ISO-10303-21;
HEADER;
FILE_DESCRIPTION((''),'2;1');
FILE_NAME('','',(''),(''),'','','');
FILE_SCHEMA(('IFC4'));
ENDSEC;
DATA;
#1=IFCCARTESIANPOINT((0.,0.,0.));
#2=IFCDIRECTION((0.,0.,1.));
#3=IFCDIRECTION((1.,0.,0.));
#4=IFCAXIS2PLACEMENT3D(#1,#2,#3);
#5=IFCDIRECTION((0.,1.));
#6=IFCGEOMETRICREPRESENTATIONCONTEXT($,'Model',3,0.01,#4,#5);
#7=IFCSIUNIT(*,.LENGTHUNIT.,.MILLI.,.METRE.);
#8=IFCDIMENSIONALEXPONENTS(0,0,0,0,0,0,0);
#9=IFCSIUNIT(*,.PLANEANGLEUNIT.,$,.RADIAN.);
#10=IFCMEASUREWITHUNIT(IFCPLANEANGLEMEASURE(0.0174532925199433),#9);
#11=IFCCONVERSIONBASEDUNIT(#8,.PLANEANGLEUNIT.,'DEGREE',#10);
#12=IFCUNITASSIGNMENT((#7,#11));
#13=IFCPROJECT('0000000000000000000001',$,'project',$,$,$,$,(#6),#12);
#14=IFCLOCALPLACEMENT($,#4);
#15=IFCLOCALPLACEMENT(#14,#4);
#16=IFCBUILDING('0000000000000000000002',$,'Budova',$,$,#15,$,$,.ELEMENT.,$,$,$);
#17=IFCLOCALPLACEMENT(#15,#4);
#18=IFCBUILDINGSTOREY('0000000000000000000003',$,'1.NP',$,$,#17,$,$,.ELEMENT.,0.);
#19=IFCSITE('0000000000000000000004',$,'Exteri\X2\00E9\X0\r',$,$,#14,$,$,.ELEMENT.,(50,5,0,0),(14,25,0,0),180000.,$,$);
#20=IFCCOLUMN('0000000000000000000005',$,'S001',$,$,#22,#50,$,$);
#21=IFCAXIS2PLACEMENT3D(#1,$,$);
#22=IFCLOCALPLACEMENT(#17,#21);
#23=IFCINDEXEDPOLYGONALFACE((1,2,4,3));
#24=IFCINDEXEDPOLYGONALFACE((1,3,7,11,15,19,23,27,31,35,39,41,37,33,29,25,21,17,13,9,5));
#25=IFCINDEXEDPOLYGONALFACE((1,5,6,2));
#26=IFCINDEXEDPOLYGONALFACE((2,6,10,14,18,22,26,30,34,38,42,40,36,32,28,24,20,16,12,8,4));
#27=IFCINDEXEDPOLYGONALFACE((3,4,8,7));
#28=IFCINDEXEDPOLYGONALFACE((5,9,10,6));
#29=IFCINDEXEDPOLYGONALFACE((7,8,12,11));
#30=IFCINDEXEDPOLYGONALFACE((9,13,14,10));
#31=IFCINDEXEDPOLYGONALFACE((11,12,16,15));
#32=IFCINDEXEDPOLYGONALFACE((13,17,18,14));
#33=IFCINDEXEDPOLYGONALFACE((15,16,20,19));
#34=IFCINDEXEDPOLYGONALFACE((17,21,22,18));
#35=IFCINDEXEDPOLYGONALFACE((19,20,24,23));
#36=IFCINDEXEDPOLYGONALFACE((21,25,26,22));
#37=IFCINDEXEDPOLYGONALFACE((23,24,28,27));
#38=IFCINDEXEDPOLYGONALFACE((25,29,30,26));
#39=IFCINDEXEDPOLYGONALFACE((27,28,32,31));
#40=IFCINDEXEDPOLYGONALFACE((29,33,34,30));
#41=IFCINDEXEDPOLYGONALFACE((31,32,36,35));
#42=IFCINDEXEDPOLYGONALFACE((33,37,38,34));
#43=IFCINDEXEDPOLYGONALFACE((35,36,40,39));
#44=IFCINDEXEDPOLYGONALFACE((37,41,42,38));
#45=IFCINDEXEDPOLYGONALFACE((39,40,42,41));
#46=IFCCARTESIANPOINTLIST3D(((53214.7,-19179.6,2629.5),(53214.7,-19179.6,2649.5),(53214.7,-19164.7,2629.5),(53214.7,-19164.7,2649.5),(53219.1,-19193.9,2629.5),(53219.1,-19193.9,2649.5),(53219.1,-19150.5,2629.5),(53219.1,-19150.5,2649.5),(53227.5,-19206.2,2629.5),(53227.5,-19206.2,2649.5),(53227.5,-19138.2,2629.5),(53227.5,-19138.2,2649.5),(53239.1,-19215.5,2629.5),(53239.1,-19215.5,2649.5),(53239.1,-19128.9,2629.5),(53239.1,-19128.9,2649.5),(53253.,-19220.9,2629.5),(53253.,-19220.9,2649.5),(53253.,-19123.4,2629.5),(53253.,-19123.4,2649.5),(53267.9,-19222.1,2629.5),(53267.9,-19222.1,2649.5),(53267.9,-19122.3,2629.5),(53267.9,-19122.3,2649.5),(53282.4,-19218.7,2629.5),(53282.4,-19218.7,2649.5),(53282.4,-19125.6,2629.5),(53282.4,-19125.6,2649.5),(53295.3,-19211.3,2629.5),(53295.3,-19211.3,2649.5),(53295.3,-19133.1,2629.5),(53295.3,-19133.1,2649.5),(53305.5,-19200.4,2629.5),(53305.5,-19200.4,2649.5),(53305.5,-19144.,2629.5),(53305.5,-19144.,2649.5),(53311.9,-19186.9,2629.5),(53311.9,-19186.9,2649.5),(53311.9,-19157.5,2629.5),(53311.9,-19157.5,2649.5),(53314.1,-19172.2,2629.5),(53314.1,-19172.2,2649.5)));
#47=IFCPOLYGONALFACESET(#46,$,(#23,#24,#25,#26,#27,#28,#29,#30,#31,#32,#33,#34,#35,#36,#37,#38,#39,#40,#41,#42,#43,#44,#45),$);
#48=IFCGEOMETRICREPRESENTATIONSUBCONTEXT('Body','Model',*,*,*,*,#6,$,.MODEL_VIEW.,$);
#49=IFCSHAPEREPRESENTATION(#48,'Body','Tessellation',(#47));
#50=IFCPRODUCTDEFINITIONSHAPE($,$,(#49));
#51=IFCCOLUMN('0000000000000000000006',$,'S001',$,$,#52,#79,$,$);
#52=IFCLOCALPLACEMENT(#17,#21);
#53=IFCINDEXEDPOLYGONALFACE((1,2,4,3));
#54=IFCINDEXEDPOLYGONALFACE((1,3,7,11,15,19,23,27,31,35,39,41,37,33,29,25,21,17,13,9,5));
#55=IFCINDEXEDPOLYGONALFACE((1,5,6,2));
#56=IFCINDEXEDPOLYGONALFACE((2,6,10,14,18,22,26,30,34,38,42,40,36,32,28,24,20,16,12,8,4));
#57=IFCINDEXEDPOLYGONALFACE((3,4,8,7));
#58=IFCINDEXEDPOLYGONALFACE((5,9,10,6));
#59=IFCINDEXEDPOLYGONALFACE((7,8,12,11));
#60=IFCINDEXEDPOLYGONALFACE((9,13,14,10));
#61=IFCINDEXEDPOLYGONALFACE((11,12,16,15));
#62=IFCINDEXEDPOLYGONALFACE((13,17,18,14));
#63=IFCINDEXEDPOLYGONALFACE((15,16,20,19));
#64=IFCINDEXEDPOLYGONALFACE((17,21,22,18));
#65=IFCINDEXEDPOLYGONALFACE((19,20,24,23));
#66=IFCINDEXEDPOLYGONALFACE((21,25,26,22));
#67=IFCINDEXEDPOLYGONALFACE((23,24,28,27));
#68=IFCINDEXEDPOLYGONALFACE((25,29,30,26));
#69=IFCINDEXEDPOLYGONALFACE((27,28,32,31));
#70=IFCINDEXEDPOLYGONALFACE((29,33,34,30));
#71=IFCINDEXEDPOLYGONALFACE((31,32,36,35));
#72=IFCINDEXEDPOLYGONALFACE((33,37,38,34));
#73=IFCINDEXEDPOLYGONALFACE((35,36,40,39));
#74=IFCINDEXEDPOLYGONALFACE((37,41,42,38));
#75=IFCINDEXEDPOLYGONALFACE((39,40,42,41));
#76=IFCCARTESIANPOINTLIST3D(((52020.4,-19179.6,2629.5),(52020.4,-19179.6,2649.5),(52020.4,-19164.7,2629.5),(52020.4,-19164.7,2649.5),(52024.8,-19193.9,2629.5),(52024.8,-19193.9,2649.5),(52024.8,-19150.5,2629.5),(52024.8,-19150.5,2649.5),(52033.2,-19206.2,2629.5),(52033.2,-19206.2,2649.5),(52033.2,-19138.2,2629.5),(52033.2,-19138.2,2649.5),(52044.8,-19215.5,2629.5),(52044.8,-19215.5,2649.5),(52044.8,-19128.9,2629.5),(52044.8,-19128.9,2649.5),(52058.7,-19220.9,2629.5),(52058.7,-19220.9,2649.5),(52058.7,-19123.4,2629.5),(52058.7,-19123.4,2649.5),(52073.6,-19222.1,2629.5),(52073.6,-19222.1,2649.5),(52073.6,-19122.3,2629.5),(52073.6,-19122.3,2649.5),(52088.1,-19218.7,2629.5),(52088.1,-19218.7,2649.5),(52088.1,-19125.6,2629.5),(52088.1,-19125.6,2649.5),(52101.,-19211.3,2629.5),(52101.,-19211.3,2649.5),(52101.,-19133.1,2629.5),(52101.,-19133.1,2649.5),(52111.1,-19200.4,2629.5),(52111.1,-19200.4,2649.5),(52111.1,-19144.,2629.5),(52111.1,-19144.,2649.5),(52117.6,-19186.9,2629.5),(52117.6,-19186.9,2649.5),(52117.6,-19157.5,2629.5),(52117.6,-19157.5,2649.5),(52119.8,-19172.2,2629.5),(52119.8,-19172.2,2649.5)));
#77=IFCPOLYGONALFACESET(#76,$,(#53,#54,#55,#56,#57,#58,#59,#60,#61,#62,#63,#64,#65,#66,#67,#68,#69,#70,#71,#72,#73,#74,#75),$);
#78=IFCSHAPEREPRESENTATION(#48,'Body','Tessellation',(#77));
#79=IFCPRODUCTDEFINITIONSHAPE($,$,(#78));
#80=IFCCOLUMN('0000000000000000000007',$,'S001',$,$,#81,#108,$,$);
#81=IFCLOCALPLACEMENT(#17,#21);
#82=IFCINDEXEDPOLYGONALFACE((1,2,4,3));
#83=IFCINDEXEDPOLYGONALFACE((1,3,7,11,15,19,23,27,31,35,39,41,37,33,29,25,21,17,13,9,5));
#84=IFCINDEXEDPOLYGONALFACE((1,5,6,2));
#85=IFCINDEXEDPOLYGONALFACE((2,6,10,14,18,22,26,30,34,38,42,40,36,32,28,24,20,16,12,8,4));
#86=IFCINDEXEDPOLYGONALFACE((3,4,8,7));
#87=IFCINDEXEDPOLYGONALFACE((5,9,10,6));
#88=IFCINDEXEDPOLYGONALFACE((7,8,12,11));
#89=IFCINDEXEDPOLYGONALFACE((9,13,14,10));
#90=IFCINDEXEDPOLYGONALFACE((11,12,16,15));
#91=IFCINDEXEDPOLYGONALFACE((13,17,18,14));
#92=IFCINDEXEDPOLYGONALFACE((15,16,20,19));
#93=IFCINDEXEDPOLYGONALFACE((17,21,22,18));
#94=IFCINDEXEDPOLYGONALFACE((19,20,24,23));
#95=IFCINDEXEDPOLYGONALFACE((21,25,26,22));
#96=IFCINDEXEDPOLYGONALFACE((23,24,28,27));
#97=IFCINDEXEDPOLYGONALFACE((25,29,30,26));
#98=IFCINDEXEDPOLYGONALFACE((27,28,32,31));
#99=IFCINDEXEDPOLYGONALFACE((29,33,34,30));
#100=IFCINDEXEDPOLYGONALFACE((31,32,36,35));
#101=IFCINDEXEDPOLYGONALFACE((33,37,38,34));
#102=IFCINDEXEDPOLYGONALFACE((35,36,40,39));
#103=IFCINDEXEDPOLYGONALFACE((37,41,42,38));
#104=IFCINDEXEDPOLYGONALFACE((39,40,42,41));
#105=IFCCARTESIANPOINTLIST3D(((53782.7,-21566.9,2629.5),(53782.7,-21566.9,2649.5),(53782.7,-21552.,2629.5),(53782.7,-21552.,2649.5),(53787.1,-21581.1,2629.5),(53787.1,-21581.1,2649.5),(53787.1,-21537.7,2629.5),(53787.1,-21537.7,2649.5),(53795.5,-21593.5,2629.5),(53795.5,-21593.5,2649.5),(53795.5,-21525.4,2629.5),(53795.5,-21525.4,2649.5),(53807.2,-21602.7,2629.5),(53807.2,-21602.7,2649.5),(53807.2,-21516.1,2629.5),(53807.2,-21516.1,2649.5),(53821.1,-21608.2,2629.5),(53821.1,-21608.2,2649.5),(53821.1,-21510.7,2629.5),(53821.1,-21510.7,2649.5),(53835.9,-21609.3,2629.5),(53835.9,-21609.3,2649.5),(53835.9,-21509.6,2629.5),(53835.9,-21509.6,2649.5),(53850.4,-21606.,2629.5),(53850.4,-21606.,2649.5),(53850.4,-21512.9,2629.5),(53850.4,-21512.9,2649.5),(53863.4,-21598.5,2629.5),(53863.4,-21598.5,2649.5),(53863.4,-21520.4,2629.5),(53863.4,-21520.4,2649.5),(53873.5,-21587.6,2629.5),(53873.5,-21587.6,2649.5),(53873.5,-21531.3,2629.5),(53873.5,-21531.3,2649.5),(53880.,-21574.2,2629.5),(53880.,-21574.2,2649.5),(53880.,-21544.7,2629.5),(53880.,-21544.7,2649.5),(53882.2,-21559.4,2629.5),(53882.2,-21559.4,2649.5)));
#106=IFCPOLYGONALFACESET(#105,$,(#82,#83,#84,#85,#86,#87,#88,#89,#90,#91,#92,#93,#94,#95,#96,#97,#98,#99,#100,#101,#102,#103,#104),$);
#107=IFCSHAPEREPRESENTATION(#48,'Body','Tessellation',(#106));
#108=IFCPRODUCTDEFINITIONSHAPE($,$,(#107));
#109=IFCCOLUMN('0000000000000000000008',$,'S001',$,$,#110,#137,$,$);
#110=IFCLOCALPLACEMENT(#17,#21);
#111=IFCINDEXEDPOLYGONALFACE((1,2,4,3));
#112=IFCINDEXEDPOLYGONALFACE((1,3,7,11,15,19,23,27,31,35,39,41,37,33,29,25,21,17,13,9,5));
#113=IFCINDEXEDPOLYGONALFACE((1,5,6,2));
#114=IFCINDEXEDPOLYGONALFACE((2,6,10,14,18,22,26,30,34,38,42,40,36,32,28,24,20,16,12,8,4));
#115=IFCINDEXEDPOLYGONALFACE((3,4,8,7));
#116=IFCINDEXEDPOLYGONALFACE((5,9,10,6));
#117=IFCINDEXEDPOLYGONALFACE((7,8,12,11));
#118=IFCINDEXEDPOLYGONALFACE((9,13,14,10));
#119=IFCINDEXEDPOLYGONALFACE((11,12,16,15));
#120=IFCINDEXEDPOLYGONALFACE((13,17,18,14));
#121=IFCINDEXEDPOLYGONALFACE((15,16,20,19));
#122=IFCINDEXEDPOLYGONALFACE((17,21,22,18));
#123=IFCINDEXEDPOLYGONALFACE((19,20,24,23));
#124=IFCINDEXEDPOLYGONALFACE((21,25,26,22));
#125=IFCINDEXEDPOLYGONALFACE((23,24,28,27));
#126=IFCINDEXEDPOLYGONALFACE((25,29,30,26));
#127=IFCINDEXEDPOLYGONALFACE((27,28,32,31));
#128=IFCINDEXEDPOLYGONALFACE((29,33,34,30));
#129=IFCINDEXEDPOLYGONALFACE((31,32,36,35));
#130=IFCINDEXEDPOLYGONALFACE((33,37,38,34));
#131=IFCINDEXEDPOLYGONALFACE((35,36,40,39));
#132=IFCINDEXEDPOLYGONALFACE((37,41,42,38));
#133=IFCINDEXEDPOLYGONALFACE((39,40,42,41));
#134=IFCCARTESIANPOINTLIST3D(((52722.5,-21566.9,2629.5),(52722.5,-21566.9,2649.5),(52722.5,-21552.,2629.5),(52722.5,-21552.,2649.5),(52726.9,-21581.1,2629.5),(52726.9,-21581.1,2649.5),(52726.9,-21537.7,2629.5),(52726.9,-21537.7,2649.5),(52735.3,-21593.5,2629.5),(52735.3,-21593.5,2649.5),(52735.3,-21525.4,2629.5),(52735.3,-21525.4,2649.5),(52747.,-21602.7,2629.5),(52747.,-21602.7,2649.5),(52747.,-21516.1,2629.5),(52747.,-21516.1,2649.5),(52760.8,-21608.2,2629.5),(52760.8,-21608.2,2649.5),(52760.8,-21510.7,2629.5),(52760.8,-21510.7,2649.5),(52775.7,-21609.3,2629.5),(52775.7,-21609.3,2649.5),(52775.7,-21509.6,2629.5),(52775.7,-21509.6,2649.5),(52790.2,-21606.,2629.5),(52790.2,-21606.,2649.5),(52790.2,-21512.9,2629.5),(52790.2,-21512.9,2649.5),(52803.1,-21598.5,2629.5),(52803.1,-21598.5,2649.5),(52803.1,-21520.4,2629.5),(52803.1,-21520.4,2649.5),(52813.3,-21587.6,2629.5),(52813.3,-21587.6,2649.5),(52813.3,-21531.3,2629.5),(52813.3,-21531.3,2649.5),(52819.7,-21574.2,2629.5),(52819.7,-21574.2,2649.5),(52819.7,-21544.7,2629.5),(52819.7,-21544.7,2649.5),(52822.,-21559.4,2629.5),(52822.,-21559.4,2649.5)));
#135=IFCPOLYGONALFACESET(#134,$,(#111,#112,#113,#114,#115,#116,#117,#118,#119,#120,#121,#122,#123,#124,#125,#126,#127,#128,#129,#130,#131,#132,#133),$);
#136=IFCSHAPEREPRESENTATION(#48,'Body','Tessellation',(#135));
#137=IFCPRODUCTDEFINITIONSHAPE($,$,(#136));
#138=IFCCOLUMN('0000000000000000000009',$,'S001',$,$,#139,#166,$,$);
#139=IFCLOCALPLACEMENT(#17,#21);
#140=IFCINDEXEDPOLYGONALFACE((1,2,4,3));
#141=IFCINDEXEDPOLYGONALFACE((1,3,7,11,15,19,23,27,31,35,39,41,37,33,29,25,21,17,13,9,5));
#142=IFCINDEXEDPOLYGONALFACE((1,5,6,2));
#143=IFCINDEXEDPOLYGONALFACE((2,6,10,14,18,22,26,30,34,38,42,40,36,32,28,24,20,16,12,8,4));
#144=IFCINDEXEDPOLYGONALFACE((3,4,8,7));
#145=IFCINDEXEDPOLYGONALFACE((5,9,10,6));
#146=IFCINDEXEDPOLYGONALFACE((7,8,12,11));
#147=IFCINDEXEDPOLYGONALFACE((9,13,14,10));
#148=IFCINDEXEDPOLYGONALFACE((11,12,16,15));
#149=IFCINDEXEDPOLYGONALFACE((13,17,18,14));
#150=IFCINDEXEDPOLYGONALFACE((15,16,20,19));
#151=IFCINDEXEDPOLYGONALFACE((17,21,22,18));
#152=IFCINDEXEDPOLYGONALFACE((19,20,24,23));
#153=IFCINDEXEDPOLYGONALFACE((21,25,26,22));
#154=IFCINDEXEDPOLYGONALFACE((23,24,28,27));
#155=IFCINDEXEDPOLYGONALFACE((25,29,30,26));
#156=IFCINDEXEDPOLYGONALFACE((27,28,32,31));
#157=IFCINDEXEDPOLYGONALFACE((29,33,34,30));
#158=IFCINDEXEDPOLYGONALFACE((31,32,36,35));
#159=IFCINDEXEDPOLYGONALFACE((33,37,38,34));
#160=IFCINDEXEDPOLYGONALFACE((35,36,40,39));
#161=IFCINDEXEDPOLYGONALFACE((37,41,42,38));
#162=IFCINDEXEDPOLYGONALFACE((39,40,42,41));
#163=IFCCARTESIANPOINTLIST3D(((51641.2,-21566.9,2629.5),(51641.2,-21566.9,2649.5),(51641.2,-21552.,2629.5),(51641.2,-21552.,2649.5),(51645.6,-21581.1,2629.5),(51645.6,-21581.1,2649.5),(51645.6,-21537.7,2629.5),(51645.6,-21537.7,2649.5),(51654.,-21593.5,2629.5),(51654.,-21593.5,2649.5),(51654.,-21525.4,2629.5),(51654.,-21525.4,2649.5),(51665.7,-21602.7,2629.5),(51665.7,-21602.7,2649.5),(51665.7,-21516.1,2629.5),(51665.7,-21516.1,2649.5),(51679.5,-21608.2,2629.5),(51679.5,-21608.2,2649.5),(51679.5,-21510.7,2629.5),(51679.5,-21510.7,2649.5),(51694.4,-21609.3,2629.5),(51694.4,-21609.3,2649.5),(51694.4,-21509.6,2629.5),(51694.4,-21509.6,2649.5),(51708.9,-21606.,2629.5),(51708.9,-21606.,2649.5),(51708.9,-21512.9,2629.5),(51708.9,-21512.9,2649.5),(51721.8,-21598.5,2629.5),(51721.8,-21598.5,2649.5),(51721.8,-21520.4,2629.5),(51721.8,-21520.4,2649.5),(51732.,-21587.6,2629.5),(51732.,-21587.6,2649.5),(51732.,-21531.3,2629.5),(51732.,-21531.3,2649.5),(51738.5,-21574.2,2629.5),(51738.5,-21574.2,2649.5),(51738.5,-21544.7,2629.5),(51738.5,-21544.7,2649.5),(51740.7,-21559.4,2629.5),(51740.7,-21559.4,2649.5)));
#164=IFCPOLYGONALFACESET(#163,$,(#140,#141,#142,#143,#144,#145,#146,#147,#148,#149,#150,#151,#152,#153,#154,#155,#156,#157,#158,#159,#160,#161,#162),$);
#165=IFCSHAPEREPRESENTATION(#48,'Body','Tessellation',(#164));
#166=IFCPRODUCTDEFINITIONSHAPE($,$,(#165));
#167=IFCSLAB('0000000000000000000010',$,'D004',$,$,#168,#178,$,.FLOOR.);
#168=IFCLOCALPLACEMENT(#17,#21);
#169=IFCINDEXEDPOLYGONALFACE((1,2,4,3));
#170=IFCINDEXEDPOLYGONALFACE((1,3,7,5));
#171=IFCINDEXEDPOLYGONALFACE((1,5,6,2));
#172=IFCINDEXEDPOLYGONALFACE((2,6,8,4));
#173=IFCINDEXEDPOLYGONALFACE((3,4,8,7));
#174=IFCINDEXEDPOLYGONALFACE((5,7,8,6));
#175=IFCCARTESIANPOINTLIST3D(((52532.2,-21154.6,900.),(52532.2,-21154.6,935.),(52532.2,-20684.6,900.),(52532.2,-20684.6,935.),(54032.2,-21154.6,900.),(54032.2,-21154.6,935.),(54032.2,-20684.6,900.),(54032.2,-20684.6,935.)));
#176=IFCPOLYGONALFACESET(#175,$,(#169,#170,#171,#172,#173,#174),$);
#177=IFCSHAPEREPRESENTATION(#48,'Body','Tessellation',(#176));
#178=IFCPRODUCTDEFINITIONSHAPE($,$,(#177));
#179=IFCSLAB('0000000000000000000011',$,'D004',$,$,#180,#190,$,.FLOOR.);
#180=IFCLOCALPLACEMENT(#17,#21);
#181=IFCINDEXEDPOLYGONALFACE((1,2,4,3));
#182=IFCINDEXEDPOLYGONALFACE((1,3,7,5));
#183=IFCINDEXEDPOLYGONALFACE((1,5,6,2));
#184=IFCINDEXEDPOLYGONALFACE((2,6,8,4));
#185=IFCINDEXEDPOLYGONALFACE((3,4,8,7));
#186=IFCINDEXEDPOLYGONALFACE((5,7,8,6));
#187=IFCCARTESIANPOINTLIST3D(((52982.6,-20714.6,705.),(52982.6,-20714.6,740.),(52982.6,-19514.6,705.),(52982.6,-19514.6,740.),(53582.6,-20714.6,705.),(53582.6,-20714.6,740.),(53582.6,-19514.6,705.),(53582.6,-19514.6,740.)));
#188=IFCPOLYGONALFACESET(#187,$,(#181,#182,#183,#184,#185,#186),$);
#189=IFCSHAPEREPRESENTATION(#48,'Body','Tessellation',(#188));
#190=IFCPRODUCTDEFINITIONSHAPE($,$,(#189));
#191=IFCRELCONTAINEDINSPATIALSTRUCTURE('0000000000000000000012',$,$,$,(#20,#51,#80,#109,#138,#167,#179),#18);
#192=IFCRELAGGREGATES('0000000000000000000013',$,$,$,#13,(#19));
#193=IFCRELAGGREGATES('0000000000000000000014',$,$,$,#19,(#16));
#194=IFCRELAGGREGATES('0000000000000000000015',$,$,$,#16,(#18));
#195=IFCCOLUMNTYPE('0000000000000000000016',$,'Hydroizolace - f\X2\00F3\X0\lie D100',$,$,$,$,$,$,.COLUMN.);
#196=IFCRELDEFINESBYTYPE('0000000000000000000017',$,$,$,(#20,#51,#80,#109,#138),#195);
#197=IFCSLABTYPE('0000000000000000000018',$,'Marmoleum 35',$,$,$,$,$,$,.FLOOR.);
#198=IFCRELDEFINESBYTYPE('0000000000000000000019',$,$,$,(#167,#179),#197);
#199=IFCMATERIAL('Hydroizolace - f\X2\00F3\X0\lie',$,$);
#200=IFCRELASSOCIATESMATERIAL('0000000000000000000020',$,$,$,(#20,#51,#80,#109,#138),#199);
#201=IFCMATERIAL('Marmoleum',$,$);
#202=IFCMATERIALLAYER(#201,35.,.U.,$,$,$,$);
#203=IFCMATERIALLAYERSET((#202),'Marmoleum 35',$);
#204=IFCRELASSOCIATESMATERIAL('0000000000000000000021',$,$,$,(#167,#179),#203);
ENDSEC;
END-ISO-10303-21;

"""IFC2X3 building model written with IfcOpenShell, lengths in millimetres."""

from ifc_helpers import new_model, entity, si_unit, converted_unit, direction, frame, origin_with_axes, origin_2d_with_axis, place, context, subcontext, project, spatial, polyline, circle, outline, extrude, material, layer, layer_set, layer_usage, type_object, element, save


model = new_model("IFC2X3")

# Units and contexts
model_context = context("Model", 3, precision=0.01, world=origin_with_axes(), true_north=direction((0.0, 1.0)))
body_context = subcontext(model_context, "Body", "Model", "MODEL_VIEW")
ifc_project = project(units=[si_unit("LENGTHUNIT", "METRE", prefix="MILLI"), converted_unit("PLANEANGLEUNIT", "DEGREE", entity("IfcPlaneAngleMeasure", 0.0174532925199433), si_unit("PLANEANGLEUNIT", "RADIAN"), dimensions=[0, 0, 0, 0, 0, 0, 0])], contexts=[model_context])

# Site, building, storey
site_placement = place(None, origin_with_axes())
site = spatial("IfcSite", under=ifc_project, at=site_placement, Name="Exteriér", CompositionType="ELEMENT", RefLatitude=(50, 5, 0, 0), RefLongitude=(14, 25, 0, 0), RefElevation=180000.0)
building_placement = place(site_placement, origin_with_axes())
building = spatial("IfcBuilding", under=site, at=building_placement, Name="Budova", CompositionType="ELEMENT")
storey_placement = place(building_placement, origin_with_axes())
storey = spatial("IfcBuildingStorey", under=building, at=storey_placement, Name="1.NP", CompositionType="ELEMENT", Elevation=0.0)

# Columns
ifc_material_1 = material(Name="Hydroizolace - fólie")
column_type = type_object("IfcColumnType", Name="Hydroizolace - fólie D100", PredefinedType="COLUMN")
for number, where, z_axis, x_axis, name in (
    (1, (53264.1, -19172.2, 2629.5), (0.0, 0.0, 1.0), (1.0, 0.0, 0.0), "S001"),
    (2, (52069.8, -19172.2, 2629.5), (0.0, 0.0, 1.0), (1.0, 0.0, 0.0), "S001"),
    (3, (53832.2, -21559.4, 2629.5), (0.0, 0.0, 1.0), (1.0, 0.0, 0.0), "S001"),
    (4, (52772.0, -21559.4, 2629.5), (0.0, 0.0, 1.0), (1.0, 0.0, 0.0), "S001"),
    (5, (51690.7, -21559.4, 2629.5), (0.0, 0.0, 1.0), (1.0, 0.0, 0.0), "S001"),
):
    element("IfcColumn", number, at=place(storey_placement, frame(where, z_axis=z_axis, x_axis=x_axis)), inside=storey, type_object=column_type, material=ifc_material_1, Name=name, context=body_context, shape_type="SweptSolid", body=[
        extrude(circle(Radius=50.0, at=origin_2d_with_axis()), origin_with_axes(), (0.0, 0.0, 1.0), 20.0),
    ])

# Slabs
ifc_material_2 = material(Name="Marmoleum")
ifc_layer_1 = layer(ifc_material_2, 35.0, ventilated="UNKNOWN")
ifc_layer_set_1 = layer_set([ifc_layer_1], Name="Marmoleum 35")
ifc_layer_usage_1 = layer_usage(ifc_layer_set_1, "AXIS3", "NEGATIVE", 35.0)
slab_type = type_object("IfcSlabType", Name="Marmoleum 35", PredefinedType="FLOOR")
slab_1_placement = place(storey_placement, frame((52532.2, -21154.6, 935.0), z_axis=(0.0, 0.0, 1.0), x_axis=(1.0, 0.0, 0.0)))
element("IfcSlab", 6, at=slab_1_placement, inside=storey, type_object=slab_type, material=ifc_layer_usage_1, Name="D004", PredefinedType="FLOOR", context=body_context, shape_type="SweptSolid", body=[
    extrude(outline(polyline([(0.0, 0.0), (1500.0, 0.0), (1500.0, 470.0), (0.0, 470.0), (0.0, 0.0)])), frame((0.0, 0.0, -35.0), z_axis=(0.0, 0.0, 1.0), x_axis=(1.0, 0.0, 0.0)), (0.0, 0.0, 1.0), 35.0),
])
ifc_layer_usage_2 = layer_usage(ifc_layer_set_1, "AXIS3", "NEGATIVE", 35.0)
slab_2_placement = place(storey_placement, frame((53582.6, -19514.6, 740.0), z_axis=(0.0, 0.0, 1.0), x_axis=(1.0, 0.0, 0.0)))
element("IfcSlab", 7, at=slab_2_placement, inside=storey, type_object=slab_type, material=ifc_layer_usage_2, Name="D004", PredefinedType="FLOOR", context=body_context, shape_type="SweptSolid", body=[
    extrude(outline(polyline([(0.0, 0.0), (-600.0, 0.0), (-600.0, -1200.0), (0.0, -1200.0), (0.0, 0.0)])), frame((0.0, 0.0, -35.0), z_axis=(0.0, 0.0, 1.0), x_axis=(1.0, 0.0, 0.0)), (0.0, 0.0, 1.0), 35.0),
])

save(model, "model.ifc")
